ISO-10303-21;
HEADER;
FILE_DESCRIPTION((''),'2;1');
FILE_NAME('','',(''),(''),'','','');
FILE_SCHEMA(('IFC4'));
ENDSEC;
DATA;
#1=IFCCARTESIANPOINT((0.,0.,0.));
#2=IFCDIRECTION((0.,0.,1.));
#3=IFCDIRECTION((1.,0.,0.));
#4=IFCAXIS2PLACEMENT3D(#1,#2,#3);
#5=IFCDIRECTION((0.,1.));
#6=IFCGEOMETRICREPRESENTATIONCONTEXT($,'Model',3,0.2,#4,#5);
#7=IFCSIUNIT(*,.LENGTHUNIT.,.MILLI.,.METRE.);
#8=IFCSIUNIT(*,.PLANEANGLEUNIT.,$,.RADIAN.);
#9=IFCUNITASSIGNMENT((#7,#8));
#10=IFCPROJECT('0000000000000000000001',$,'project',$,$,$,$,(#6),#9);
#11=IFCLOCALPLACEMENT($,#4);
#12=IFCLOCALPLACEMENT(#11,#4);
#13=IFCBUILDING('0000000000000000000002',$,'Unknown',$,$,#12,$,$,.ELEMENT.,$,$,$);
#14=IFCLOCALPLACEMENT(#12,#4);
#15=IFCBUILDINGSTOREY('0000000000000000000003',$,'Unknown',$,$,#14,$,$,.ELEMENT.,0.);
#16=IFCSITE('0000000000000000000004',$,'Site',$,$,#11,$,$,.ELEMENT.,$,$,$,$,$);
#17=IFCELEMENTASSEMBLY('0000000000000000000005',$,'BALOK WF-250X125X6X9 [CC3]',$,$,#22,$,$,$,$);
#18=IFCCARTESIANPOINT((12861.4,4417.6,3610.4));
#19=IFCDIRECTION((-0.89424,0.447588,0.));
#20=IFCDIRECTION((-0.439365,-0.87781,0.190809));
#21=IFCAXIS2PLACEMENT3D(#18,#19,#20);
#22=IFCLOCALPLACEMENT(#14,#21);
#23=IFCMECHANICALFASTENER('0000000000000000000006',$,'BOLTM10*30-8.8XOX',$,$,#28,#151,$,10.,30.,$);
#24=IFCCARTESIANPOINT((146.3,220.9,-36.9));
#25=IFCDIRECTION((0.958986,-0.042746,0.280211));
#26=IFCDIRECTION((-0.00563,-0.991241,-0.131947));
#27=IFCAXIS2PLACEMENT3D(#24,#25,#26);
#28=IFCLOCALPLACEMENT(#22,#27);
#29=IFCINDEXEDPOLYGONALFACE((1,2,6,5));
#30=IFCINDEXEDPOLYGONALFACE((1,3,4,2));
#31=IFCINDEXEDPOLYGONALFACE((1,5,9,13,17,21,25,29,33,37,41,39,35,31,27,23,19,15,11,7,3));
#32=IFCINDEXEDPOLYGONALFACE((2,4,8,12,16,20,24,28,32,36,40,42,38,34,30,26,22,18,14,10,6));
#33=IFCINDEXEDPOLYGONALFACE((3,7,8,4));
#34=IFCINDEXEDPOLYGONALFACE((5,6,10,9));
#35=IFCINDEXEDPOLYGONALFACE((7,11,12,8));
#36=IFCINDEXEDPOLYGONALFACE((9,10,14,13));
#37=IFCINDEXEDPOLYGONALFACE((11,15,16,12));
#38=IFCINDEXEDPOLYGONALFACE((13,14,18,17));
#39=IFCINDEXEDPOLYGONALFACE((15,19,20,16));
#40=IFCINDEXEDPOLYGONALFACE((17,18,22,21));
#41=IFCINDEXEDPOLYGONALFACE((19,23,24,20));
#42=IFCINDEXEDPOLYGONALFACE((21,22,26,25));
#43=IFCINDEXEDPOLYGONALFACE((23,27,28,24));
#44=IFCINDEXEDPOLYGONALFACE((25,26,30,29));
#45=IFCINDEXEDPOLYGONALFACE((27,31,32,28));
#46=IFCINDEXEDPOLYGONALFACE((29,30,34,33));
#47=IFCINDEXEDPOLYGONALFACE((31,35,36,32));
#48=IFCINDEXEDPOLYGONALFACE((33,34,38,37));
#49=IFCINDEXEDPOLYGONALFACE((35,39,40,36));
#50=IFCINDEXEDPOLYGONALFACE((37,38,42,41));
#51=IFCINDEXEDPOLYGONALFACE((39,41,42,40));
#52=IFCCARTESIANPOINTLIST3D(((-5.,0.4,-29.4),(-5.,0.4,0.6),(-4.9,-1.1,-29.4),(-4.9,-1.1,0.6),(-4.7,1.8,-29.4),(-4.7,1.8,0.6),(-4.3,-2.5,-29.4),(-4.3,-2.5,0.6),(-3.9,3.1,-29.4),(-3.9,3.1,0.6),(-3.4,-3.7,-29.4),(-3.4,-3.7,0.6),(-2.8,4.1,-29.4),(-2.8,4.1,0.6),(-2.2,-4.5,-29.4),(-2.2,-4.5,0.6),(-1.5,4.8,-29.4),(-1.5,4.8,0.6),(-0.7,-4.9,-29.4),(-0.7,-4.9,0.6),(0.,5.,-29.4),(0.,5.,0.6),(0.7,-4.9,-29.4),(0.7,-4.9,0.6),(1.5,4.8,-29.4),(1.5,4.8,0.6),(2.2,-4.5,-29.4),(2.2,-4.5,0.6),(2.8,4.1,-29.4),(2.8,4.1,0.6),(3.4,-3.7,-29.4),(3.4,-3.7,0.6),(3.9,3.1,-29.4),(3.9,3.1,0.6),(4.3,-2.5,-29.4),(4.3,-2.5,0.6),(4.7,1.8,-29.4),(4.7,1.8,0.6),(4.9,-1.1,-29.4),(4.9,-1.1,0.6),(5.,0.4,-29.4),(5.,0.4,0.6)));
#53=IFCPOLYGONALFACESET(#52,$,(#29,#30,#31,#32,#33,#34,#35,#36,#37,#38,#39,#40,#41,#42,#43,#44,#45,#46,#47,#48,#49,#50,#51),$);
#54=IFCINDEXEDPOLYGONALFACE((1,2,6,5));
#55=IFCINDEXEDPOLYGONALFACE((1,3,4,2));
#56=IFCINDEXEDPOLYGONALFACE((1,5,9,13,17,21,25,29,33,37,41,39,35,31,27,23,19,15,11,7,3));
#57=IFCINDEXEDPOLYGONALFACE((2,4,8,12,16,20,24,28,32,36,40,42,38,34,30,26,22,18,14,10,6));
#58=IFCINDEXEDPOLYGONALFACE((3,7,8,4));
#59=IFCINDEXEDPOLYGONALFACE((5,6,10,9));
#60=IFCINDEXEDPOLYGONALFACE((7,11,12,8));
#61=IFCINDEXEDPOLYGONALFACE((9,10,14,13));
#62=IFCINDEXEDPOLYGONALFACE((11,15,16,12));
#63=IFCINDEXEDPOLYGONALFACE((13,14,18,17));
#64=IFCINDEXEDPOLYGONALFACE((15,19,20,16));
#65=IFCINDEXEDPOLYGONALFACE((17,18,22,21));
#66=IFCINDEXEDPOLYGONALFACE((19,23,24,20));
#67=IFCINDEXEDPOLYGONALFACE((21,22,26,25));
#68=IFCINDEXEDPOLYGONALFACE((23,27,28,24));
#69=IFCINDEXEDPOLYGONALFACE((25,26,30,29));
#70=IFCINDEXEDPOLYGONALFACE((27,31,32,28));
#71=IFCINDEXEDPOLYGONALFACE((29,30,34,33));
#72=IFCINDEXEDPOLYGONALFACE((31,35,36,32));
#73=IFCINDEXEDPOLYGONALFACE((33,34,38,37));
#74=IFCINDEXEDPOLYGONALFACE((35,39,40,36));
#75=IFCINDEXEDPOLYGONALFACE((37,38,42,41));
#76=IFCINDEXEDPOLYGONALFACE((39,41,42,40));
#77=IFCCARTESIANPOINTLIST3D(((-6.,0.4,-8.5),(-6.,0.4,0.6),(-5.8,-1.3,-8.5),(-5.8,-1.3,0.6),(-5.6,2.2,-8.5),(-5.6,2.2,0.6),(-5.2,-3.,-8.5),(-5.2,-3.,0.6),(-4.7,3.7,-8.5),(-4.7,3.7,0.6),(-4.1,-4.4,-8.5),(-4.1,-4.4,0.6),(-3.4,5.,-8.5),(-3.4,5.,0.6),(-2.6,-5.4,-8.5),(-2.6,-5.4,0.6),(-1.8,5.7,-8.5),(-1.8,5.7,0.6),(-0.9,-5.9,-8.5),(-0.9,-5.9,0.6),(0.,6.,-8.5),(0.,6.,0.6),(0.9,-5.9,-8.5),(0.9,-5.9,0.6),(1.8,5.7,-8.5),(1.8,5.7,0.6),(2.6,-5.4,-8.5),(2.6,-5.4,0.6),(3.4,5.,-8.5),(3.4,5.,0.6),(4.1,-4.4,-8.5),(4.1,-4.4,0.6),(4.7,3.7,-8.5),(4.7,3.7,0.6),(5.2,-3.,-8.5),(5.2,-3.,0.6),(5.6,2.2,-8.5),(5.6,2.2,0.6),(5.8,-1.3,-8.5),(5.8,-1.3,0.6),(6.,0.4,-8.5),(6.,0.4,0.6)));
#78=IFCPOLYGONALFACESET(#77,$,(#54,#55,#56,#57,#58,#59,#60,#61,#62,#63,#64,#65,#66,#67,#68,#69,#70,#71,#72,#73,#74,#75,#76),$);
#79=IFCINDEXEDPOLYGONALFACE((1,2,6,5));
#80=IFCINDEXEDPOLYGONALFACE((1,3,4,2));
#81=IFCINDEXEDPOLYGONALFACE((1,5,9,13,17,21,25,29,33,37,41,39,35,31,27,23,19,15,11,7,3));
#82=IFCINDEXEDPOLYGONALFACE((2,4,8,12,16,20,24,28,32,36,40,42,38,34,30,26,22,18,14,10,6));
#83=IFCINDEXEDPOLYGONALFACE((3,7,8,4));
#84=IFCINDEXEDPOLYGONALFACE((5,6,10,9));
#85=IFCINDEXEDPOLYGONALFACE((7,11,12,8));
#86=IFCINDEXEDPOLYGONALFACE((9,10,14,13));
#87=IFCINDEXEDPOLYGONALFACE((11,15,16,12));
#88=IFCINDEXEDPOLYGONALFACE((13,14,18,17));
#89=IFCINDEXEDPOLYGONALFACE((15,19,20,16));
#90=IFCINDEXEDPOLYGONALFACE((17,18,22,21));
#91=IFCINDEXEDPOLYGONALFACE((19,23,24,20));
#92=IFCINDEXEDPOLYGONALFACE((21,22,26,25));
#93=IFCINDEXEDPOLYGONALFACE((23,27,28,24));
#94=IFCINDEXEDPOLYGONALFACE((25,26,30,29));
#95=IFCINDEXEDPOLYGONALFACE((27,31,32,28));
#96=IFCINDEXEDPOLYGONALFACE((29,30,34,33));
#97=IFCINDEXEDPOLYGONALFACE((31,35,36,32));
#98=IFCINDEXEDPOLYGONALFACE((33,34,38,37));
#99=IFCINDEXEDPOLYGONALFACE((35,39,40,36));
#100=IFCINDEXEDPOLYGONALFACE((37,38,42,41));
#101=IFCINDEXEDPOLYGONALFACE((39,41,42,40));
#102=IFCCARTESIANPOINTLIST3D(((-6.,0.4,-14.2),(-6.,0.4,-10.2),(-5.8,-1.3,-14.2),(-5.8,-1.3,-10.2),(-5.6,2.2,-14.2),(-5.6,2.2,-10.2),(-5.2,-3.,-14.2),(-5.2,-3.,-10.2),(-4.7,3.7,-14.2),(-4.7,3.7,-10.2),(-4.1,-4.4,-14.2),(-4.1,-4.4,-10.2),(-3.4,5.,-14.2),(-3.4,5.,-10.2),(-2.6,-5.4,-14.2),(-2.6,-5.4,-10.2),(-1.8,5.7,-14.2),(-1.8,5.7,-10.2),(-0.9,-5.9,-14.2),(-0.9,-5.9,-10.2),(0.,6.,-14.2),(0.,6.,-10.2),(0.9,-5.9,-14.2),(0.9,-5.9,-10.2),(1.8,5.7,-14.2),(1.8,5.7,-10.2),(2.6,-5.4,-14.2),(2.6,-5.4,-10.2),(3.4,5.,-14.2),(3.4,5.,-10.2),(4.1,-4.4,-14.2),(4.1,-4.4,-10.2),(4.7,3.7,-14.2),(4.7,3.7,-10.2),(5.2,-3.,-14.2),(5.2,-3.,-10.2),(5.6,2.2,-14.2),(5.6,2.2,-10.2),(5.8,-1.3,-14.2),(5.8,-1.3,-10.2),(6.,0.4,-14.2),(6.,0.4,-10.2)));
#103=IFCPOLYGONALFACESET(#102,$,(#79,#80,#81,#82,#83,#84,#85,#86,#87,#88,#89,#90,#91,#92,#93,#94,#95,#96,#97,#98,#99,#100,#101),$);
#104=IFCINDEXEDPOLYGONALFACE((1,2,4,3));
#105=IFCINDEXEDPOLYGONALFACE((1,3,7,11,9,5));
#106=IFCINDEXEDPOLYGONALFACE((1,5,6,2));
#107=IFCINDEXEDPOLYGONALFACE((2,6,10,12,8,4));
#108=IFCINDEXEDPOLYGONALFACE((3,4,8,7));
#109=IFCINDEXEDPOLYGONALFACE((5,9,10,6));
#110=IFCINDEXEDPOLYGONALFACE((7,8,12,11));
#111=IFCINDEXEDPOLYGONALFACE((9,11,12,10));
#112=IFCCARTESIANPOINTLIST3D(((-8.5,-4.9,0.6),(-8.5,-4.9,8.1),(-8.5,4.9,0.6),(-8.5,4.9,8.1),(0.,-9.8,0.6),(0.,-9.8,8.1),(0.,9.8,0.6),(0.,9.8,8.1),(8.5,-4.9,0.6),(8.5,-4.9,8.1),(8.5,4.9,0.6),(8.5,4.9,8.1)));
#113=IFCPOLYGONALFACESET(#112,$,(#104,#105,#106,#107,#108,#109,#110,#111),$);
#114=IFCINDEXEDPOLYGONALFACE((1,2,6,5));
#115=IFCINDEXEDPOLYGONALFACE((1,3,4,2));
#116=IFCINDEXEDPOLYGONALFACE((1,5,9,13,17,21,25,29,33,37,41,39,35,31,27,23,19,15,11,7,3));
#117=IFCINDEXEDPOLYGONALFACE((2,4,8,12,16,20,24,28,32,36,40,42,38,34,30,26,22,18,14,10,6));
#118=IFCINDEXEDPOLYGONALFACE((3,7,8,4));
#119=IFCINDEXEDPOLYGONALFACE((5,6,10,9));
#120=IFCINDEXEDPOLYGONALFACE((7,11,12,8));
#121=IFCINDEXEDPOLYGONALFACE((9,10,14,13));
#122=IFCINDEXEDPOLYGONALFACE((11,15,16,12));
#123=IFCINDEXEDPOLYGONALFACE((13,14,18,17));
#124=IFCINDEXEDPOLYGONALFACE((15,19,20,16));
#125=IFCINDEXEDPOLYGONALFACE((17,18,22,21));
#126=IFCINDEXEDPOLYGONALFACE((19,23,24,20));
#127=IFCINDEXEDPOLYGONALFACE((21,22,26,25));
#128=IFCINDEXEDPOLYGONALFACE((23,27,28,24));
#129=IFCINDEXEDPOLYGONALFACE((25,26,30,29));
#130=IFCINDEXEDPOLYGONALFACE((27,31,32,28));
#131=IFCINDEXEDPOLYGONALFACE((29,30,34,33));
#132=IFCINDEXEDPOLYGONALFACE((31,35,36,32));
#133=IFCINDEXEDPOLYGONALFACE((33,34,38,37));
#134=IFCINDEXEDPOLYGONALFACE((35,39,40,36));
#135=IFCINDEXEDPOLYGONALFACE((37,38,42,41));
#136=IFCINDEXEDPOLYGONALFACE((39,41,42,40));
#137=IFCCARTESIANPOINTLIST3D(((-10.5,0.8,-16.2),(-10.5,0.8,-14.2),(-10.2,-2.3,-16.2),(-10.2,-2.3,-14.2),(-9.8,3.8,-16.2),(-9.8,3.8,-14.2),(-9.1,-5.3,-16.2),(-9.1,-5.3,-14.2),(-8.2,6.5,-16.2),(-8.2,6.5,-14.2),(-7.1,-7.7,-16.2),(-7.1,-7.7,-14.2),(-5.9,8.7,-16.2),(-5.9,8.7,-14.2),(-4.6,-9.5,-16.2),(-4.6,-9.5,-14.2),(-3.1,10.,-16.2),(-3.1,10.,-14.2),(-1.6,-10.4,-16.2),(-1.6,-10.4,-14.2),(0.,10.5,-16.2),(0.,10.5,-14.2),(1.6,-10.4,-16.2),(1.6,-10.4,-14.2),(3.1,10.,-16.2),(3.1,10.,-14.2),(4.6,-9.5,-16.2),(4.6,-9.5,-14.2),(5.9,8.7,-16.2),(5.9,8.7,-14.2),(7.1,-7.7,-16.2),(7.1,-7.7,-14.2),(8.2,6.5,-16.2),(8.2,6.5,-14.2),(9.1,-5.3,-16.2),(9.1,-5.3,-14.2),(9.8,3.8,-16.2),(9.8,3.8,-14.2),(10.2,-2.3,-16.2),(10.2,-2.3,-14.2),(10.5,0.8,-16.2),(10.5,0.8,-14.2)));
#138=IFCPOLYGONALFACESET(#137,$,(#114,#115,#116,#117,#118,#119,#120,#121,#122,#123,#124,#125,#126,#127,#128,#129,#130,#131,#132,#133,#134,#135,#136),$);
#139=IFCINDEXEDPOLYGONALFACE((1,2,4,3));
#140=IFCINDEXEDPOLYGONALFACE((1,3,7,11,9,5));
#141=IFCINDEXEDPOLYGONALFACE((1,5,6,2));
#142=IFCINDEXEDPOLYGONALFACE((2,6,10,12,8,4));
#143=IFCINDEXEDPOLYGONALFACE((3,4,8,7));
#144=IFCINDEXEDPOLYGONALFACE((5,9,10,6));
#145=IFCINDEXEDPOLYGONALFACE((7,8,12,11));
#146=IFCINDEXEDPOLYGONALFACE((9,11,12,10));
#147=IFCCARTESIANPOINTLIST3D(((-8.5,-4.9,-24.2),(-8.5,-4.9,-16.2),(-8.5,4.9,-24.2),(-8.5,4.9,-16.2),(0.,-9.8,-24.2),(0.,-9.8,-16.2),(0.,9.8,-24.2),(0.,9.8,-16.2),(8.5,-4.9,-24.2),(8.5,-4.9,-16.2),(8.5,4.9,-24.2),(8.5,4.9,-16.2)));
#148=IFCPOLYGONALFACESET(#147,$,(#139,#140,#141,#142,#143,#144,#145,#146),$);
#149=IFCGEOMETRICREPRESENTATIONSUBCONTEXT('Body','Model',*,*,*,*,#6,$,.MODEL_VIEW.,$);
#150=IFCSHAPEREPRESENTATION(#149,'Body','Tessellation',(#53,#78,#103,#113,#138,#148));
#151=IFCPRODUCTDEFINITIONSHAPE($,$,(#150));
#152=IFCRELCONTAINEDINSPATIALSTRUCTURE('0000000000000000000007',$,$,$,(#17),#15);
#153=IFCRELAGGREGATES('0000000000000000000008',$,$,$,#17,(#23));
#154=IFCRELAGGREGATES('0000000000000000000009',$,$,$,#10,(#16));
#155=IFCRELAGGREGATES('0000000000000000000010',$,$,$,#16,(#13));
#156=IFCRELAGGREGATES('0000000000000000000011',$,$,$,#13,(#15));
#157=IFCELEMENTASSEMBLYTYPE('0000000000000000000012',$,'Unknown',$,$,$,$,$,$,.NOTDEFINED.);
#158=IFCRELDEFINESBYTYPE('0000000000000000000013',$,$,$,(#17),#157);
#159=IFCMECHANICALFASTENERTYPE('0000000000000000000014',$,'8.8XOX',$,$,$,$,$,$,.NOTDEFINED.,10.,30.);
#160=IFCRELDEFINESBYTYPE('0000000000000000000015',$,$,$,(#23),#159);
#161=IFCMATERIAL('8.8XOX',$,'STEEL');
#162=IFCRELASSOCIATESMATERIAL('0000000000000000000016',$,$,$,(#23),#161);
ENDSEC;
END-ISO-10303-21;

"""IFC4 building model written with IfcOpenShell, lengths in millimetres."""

from ifc_helpers import new_model, si_unit, direction, frame, origin_with_axes, origin_2d_with_axis, place, context, subcontext, project, spatial, polyline, circle, outline, extrude, source, transform, mapped, material, type_object, element, aggregate, save


model = new_model("IFC4")

# Units and contexts
model_context = context("Model", 3, precision=0.2, world=origin_with_axes(), true_north=direction((0.0, 1.0)))
body_context = subcontext(model_context, "Body", "Model", "MODEL_VIEW")
ifc_project = project(units=[si_unit("LENGTHUNIT", "METRE", prefix="MILLI"), si_unit("PLANEANGLEUNIT", "RADIAN")], contexts=[model_context])

# Site, building, storey
site_placement = place(None, origin_with_axes())
site = spatial("IfcSite", under=ifc_project, at=site_placement, Name="Site", CompositionType="ELEMENT")
building_placement = place(site_placement, origin_with_axes())
building = spatial("IfcBuilding", under=site, at=building_placement, Name="Unknown", CompositionType="ELEMENT")
storey_placement = place(building_placement, origin_with_axes())
storey = spatial("IfcBuildingStorey", under=building, at=storey_placement, Name="Unknown", CompositionType="ELEMENT", Elevation=0.0)

# Element assembly
element_assembly_type = type_object("IfcElementAssemblyType", Name="Unknown", PredefinedType="NOTDEFINED")
assembly_1_placement = place(storey_placement, frame((12861.4, 4417.6, 3610.4), z_axis=(-0.89424, 0.447588, 0.0), x_axis=(-0.439365, -0.87781, 0.190809)))
assembly_1 = element("IfcElementAssembly", 1, at=assembly_1_placement, inside=storey, type_object=element_assembly_type, Name="BALOK WF-250X125X6X9 [CC3]")

# Mechanical fastener
ifc_material_1 = material(Name="8.8XOX", Category="STEEL")
mechanical_fastener_type_1 = type_object("IfcMechanicalFastenerType", Name="8.8XOX", NominalDiameter=10.0, NominalLength=30.0, PredefinedType="NOTDEFINED")
shared_shape_1 = source(origin_with_axes(), body_context, "Body", "SweptSolid", [
    extrude(circle(Radius=5.0, at=origin_2d_with_axis()), frame((0.0, 0.0, 0.6), z_axis=(0.0, 0.0, -1.0), x_axis=(0.0, 1.0, 0.0)), (0.0, 0.0, 1.0), 30.0),
    extrude(circle(Radius=6.0, at=origin_2d_with_axis()), frame((0.0, 0.0, 0.6), z_axis=(0.0, 0.0, -1.0), x_axis=(0.0, 1.0, 0.0)), (0.0, 0.0, 1.0), 9.1),
    extrude(circle(Radius=6.0, at=origin_2d_with_axis()), frame((0.0, 0.0, -10.2), z_axis=(0.0, 0.0, -1.0), x_axis=(0.0, 1.0, 0.0)), (0.0, 0.0, 1.0), 4.0),
    extrude(outline(polyline([(9.8, 0.0), (4.9, 8.5), (-4.9, 8.5), (-9.8, 0.0), (-4.9, -8.5), (4.9, -8.5), (9.8, 0.0)])), frame((0.0, 0.0, 8.1), z_axis=(0.0, 0.0, -1.0), x_axis=(0.0, 1.0, 0.0)), (0.0, 0.0, 1.0), 7.5),
    extrude(circle(Radius=10.5, at=origin_2d_with_axis()), frame((0.0, 0.0, -14.2), z_axis=(0.0, 0.0, -1.0), x_axis=(0.0, 1.0, 0.0)), (0.0, 0.0, 1.0), 2.0),
    extrude(outline(polyline([(9.8, 0.0), (4.9, 8.5), (-4.9, 8.5), (-9.8, 0.0), (-4.9, -8.5), (4.9, -8.5), (9.8, 0.0)])), frame((0.0, 0.0, -16.2), z_axis=(0.0, 0.0, -1.0), x_axis=(0.0, 1.0, 0.0)), (0.0, 0.0, 1.0), 8.0),
])
mechanical_fastener_1_placement = place(assembly_1_placement, frame((146.3, 220.9, -36.9), z_axis=(0.958986, -0.042746, 0.280211), x_axis=(-0.00563, -0.991241, -0.131947)))
mechanical_fastener_1 = element("IfcMechanicalFastener", 2, at=mechanical_fastener_1_placement, type_object=mechanical_fastener_type_1, material=ifc_material_1, Name="BOLTM10*30-8.8XOX", NominalDiameter=10.0, NominalLength=30.0, context=body_context, shape_type="MappedRepresentation", body=[
    mapped(shared_shape_1, transform((0.0, 0.0, 0.0))),
])
aggregate(assembly_1, [mechanical_fastener_1])

save(model, "model.ifc")
